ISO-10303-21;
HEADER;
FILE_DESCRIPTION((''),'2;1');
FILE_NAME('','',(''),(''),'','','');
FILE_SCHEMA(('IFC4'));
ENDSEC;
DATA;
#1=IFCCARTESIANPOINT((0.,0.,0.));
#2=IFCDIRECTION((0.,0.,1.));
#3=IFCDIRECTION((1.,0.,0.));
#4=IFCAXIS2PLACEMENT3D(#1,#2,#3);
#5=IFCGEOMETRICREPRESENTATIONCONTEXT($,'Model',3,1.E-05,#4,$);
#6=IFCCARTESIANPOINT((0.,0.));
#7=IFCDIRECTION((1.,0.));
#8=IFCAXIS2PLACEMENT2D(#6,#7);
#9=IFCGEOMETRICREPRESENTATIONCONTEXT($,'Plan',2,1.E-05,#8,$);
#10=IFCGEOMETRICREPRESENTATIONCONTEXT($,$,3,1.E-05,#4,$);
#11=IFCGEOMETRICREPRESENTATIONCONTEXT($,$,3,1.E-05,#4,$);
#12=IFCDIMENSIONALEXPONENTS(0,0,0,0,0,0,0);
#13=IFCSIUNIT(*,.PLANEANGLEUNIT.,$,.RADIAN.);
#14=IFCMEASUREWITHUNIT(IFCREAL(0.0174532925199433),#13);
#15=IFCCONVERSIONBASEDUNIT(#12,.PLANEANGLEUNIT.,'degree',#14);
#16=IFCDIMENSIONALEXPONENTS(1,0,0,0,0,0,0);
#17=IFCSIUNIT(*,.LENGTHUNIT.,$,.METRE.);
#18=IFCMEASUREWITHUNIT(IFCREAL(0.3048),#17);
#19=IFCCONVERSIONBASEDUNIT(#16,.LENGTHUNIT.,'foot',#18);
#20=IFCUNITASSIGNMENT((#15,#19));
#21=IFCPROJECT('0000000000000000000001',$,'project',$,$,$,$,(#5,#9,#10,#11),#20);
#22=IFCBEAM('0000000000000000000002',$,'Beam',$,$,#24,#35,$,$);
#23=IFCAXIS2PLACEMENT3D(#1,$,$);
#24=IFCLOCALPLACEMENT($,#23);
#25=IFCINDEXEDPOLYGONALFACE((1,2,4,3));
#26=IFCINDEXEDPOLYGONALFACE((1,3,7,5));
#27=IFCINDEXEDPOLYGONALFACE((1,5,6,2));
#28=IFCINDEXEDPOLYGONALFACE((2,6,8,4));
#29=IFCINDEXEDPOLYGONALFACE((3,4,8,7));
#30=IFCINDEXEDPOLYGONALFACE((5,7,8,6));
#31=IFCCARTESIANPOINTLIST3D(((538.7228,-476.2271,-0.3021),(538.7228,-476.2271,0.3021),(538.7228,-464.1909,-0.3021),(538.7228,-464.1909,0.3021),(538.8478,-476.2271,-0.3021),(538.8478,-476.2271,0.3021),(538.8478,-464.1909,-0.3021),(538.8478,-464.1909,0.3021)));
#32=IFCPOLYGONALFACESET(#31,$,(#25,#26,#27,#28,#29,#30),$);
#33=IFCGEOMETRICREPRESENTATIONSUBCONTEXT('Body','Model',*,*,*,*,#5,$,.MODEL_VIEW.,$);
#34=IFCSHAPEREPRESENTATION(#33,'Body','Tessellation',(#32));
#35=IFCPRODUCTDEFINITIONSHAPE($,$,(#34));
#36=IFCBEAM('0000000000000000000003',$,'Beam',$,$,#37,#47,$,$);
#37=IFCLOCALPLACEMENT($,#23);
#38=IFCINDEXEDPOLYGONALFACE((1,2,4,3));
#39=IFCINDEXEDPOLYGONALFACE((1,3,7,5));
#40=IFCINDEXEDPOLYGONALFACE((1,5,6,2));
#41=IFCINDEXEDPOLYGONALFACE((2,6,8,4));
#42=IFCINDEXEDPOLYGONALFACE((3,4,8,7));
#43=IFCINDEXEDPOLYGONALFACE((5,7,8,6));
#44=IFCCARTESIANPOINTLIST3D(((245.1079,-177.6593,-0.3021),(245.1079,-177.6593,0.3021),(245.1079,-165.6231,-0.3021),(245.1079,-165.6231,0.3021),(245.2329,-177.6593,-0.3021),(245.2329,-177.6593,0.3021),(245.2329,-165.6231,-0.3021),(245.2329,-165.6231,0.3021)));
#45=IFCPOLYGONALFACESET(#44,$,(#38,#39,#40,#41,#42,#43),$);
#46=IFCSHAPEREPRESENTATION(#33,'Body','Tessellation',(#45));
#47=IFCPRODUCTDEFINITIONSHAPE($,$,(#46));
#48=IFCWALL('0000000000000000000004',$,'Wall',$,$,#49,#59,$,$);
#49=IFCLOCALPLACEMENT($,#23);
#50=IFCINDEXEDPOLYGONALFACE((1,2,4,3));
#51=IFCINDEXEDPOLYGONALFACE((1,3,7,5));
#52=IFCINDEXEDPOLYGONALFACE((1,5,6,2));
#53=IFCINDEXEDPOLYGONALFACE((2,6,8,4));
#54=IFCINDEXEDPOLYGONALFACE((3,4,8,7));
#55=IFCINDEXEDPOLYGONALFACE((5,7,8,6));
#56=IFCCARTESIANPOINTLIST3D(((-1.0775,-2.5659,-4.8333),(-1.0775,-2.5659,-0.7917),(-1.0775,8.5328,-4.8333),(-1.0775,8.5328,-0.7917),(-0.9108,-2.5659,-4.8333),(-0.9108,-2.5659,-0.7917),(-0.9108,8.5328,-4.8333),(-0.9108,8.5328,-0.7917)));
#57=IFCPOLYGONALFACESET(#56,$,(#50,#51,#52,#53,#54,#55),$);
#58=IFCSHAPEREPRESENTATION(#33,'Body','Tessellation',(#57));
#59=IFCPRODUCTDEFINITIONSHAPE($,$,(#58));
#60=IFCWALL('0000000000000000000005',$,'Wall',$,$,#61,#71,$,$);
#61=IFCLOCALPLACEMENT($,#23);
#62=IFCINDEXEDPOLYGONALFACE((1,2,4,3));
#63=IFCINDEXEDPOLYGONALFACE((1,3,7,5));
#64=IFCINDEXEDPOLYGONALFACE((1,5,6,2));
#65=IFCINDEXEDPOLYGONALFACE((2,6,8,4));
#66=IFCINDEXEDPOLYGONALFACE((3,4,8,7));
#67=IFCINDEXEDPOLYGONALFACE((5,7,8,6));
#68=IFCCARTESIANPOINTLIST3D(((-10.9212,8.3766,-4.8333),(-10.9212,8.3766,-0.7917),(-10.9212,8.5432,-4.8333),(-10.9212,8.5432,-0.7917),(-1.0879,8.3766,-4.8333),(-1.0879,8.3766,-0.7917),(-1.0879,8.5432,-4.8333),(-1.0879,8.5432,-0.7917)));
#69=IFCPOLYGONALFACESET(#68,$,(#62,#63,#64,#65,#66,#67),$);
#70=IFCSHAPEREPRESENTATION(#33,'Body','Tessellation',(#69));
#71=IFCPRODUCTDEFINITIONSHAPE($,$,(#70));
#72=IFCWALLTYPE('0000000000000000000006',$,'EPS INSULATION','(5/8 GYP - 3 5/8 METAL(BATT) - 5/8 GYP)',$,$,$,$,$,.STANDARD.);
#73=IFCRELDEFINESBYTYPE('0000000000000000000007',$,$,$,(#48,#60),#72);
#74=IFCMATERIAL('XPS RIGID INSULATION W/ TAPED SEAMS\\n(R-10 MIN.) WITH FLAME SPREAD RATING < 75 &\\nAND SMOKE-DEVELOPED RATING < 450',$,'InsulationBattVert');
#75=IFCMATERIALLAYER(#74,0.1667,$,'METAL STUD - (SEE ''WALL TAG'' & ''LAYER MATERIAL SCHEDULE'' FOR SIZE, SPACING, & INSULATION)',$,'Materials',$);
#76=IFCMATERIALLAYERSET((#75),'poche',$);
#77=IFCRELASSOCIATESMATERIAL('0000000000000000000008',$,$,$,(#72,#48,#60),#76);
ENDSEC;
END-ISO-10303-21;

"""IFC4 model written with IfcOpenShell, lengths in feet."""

from ifc_helpers import new_model, entity, si_unit, converted_unit, frame, origin_with_axes, origin_2d_with_axis, place, context, subcontext, project, indexed_curve, rectangle, outline, extrude, material, layer, layer_set, layer_usage, type_object, element, save


model = new_model("IFC4")

# Units and contexts
model_context = context("Model", 3, precision=1e-05, world=origin_with_axes())
plan_context = context("Plan", 2, precision=1e-05, world=origin_2d_with_axis())
context_of_model_1 = context(None, 3, precision=1e-05, world=origin_with_axes())
context_of_model_2 = context(None, 3, precision=1e-05, world=origin_with_axes())
body_context = subcontext(model_context, "Body", "Model", "MODEL_VIEW")
ifc_project = project(units=[converted_unit("PLANEANGLEUNIT", "degree", entity("IfcReal", 0.0174532925199433), si_unit("PLANEANGLEUNIT", "RADIAN"), dimensions=[0, 0, 0, 0, 0, 0, 0]), converted_unit("LENGTHUNIT", "foot", entity("IfcReal", 0.3048), si_unit("LENGTHUNIT", "METRE"), dimensions=[1, 0, 0, 0, 0, 0, 0])], contexts=[model_context, plan_context, context_of_model_1, context_of_model_2])

# Beams
for number, where, z_axis, x_axis, name in (
    (1, (538.7853, -476.2271, 0.0), (0.0, 1.0, 0.0), (-1.0, 0.0, 0.0), "Beam"),
    (2, (245.1704, -177.6593, 0.0), (0.0, 1.0, 0.0), (-1.0, 0.0, 0.0), "Beam"),
):
    element("IfcBeam", number, at=place(None, frame(where, z_axis=z_axis, x_axis=x_axis)), Name=name, context=body_context, shape_type="SweptSolid", body=[
        extrude(rectangle(XDim=0.125, YDim=0.6042), origin_with_axes(), (0.0, 0.0, 1.0), 12.0362),
    ])

# Walls
ifc_material_1 = material(Name="XPS RIGID INSULATION W/ TAPED SEAMS\\n(R-10 MIN.) WITH FLAME SPREAD RATING < 75 &\\nAND SMOKE-DEVELOPED RATING < 450", Category="InsulationBattVert")
ifc_layer_1 = layer(ifc_material_1, 0.1667, Name="METAL STUD - (SEE 'WALL TAG' & 'LAYER MATERIAL SCHEDULE' FOR SIZE, SPACING, & INSULATION)", Category="Materials")
ifc_layer_set_1 = layer_set([ifc_layer_1], Name="poche")
ifc_layer_usage_1 = layer_usage(ifc_layer_set_1, "AXIS2", "POSITIVE", 0.0)
wall_type_1 = type_object("IfcWallType", Name="EPS INSULATION", Description="(5/8 GYP - 3 5/8 METAL(BATT) - 5/8 GYP)", PredefinedType="STANDARD", material=ifc_layer_set_1)
wall_1_placement = place(None, frame((-0.9108, -2.5659, -4.8333), z_axis=(0.0, 0.0, 1.0), x_axis=(0.0, 1.0, 0.0)))
element("IfcWall", 3, at=wall_1_placement, type_object=wall_type_1, material=ifc_layer_usage_1, Name="Wall", context=body_context, shape_type="SweptSolid", body=[
    extrude(outline(indexed_curve([(0.0, 0.0), (0.0, 0.1667), (11.0987, 0.1667), (11.0987, 0.0), (0.0, 0.0)], self_intersect=False)), origin_with_axes(), (0.0, 0.0, 1.0), 4.0417),
])
ifc_layer_usage_2 = layer_usage(ifc_layer_set_1, "AXIS2", "POSITIVE", 0.0)
wall_2_placement = place(None, frame((-1.0879, 8.5432, -4.8333), z_axis=(0.0, 0.0, 1.0), x_axis=(-1.0, 0.0, 0.0)))
element("IfcWall", 4, at=wall_2_placement, type_object=wall_type_1, material=ifc_layer_usage_2, Name="Wall", context=body_context, shape_type="SweptSolid", body=[
    extrude(outline(indexed_curve([(0.0, 0.0), (0.0, 0.1667), (9.8333, 0.1667), (9.8333, 0.0), (0.0, 0.0)], self_intersect=False)), origin_with_axes(), (0.0, 0.0, 1.0), 4.0417),
])

save(model, "model.ifc")
